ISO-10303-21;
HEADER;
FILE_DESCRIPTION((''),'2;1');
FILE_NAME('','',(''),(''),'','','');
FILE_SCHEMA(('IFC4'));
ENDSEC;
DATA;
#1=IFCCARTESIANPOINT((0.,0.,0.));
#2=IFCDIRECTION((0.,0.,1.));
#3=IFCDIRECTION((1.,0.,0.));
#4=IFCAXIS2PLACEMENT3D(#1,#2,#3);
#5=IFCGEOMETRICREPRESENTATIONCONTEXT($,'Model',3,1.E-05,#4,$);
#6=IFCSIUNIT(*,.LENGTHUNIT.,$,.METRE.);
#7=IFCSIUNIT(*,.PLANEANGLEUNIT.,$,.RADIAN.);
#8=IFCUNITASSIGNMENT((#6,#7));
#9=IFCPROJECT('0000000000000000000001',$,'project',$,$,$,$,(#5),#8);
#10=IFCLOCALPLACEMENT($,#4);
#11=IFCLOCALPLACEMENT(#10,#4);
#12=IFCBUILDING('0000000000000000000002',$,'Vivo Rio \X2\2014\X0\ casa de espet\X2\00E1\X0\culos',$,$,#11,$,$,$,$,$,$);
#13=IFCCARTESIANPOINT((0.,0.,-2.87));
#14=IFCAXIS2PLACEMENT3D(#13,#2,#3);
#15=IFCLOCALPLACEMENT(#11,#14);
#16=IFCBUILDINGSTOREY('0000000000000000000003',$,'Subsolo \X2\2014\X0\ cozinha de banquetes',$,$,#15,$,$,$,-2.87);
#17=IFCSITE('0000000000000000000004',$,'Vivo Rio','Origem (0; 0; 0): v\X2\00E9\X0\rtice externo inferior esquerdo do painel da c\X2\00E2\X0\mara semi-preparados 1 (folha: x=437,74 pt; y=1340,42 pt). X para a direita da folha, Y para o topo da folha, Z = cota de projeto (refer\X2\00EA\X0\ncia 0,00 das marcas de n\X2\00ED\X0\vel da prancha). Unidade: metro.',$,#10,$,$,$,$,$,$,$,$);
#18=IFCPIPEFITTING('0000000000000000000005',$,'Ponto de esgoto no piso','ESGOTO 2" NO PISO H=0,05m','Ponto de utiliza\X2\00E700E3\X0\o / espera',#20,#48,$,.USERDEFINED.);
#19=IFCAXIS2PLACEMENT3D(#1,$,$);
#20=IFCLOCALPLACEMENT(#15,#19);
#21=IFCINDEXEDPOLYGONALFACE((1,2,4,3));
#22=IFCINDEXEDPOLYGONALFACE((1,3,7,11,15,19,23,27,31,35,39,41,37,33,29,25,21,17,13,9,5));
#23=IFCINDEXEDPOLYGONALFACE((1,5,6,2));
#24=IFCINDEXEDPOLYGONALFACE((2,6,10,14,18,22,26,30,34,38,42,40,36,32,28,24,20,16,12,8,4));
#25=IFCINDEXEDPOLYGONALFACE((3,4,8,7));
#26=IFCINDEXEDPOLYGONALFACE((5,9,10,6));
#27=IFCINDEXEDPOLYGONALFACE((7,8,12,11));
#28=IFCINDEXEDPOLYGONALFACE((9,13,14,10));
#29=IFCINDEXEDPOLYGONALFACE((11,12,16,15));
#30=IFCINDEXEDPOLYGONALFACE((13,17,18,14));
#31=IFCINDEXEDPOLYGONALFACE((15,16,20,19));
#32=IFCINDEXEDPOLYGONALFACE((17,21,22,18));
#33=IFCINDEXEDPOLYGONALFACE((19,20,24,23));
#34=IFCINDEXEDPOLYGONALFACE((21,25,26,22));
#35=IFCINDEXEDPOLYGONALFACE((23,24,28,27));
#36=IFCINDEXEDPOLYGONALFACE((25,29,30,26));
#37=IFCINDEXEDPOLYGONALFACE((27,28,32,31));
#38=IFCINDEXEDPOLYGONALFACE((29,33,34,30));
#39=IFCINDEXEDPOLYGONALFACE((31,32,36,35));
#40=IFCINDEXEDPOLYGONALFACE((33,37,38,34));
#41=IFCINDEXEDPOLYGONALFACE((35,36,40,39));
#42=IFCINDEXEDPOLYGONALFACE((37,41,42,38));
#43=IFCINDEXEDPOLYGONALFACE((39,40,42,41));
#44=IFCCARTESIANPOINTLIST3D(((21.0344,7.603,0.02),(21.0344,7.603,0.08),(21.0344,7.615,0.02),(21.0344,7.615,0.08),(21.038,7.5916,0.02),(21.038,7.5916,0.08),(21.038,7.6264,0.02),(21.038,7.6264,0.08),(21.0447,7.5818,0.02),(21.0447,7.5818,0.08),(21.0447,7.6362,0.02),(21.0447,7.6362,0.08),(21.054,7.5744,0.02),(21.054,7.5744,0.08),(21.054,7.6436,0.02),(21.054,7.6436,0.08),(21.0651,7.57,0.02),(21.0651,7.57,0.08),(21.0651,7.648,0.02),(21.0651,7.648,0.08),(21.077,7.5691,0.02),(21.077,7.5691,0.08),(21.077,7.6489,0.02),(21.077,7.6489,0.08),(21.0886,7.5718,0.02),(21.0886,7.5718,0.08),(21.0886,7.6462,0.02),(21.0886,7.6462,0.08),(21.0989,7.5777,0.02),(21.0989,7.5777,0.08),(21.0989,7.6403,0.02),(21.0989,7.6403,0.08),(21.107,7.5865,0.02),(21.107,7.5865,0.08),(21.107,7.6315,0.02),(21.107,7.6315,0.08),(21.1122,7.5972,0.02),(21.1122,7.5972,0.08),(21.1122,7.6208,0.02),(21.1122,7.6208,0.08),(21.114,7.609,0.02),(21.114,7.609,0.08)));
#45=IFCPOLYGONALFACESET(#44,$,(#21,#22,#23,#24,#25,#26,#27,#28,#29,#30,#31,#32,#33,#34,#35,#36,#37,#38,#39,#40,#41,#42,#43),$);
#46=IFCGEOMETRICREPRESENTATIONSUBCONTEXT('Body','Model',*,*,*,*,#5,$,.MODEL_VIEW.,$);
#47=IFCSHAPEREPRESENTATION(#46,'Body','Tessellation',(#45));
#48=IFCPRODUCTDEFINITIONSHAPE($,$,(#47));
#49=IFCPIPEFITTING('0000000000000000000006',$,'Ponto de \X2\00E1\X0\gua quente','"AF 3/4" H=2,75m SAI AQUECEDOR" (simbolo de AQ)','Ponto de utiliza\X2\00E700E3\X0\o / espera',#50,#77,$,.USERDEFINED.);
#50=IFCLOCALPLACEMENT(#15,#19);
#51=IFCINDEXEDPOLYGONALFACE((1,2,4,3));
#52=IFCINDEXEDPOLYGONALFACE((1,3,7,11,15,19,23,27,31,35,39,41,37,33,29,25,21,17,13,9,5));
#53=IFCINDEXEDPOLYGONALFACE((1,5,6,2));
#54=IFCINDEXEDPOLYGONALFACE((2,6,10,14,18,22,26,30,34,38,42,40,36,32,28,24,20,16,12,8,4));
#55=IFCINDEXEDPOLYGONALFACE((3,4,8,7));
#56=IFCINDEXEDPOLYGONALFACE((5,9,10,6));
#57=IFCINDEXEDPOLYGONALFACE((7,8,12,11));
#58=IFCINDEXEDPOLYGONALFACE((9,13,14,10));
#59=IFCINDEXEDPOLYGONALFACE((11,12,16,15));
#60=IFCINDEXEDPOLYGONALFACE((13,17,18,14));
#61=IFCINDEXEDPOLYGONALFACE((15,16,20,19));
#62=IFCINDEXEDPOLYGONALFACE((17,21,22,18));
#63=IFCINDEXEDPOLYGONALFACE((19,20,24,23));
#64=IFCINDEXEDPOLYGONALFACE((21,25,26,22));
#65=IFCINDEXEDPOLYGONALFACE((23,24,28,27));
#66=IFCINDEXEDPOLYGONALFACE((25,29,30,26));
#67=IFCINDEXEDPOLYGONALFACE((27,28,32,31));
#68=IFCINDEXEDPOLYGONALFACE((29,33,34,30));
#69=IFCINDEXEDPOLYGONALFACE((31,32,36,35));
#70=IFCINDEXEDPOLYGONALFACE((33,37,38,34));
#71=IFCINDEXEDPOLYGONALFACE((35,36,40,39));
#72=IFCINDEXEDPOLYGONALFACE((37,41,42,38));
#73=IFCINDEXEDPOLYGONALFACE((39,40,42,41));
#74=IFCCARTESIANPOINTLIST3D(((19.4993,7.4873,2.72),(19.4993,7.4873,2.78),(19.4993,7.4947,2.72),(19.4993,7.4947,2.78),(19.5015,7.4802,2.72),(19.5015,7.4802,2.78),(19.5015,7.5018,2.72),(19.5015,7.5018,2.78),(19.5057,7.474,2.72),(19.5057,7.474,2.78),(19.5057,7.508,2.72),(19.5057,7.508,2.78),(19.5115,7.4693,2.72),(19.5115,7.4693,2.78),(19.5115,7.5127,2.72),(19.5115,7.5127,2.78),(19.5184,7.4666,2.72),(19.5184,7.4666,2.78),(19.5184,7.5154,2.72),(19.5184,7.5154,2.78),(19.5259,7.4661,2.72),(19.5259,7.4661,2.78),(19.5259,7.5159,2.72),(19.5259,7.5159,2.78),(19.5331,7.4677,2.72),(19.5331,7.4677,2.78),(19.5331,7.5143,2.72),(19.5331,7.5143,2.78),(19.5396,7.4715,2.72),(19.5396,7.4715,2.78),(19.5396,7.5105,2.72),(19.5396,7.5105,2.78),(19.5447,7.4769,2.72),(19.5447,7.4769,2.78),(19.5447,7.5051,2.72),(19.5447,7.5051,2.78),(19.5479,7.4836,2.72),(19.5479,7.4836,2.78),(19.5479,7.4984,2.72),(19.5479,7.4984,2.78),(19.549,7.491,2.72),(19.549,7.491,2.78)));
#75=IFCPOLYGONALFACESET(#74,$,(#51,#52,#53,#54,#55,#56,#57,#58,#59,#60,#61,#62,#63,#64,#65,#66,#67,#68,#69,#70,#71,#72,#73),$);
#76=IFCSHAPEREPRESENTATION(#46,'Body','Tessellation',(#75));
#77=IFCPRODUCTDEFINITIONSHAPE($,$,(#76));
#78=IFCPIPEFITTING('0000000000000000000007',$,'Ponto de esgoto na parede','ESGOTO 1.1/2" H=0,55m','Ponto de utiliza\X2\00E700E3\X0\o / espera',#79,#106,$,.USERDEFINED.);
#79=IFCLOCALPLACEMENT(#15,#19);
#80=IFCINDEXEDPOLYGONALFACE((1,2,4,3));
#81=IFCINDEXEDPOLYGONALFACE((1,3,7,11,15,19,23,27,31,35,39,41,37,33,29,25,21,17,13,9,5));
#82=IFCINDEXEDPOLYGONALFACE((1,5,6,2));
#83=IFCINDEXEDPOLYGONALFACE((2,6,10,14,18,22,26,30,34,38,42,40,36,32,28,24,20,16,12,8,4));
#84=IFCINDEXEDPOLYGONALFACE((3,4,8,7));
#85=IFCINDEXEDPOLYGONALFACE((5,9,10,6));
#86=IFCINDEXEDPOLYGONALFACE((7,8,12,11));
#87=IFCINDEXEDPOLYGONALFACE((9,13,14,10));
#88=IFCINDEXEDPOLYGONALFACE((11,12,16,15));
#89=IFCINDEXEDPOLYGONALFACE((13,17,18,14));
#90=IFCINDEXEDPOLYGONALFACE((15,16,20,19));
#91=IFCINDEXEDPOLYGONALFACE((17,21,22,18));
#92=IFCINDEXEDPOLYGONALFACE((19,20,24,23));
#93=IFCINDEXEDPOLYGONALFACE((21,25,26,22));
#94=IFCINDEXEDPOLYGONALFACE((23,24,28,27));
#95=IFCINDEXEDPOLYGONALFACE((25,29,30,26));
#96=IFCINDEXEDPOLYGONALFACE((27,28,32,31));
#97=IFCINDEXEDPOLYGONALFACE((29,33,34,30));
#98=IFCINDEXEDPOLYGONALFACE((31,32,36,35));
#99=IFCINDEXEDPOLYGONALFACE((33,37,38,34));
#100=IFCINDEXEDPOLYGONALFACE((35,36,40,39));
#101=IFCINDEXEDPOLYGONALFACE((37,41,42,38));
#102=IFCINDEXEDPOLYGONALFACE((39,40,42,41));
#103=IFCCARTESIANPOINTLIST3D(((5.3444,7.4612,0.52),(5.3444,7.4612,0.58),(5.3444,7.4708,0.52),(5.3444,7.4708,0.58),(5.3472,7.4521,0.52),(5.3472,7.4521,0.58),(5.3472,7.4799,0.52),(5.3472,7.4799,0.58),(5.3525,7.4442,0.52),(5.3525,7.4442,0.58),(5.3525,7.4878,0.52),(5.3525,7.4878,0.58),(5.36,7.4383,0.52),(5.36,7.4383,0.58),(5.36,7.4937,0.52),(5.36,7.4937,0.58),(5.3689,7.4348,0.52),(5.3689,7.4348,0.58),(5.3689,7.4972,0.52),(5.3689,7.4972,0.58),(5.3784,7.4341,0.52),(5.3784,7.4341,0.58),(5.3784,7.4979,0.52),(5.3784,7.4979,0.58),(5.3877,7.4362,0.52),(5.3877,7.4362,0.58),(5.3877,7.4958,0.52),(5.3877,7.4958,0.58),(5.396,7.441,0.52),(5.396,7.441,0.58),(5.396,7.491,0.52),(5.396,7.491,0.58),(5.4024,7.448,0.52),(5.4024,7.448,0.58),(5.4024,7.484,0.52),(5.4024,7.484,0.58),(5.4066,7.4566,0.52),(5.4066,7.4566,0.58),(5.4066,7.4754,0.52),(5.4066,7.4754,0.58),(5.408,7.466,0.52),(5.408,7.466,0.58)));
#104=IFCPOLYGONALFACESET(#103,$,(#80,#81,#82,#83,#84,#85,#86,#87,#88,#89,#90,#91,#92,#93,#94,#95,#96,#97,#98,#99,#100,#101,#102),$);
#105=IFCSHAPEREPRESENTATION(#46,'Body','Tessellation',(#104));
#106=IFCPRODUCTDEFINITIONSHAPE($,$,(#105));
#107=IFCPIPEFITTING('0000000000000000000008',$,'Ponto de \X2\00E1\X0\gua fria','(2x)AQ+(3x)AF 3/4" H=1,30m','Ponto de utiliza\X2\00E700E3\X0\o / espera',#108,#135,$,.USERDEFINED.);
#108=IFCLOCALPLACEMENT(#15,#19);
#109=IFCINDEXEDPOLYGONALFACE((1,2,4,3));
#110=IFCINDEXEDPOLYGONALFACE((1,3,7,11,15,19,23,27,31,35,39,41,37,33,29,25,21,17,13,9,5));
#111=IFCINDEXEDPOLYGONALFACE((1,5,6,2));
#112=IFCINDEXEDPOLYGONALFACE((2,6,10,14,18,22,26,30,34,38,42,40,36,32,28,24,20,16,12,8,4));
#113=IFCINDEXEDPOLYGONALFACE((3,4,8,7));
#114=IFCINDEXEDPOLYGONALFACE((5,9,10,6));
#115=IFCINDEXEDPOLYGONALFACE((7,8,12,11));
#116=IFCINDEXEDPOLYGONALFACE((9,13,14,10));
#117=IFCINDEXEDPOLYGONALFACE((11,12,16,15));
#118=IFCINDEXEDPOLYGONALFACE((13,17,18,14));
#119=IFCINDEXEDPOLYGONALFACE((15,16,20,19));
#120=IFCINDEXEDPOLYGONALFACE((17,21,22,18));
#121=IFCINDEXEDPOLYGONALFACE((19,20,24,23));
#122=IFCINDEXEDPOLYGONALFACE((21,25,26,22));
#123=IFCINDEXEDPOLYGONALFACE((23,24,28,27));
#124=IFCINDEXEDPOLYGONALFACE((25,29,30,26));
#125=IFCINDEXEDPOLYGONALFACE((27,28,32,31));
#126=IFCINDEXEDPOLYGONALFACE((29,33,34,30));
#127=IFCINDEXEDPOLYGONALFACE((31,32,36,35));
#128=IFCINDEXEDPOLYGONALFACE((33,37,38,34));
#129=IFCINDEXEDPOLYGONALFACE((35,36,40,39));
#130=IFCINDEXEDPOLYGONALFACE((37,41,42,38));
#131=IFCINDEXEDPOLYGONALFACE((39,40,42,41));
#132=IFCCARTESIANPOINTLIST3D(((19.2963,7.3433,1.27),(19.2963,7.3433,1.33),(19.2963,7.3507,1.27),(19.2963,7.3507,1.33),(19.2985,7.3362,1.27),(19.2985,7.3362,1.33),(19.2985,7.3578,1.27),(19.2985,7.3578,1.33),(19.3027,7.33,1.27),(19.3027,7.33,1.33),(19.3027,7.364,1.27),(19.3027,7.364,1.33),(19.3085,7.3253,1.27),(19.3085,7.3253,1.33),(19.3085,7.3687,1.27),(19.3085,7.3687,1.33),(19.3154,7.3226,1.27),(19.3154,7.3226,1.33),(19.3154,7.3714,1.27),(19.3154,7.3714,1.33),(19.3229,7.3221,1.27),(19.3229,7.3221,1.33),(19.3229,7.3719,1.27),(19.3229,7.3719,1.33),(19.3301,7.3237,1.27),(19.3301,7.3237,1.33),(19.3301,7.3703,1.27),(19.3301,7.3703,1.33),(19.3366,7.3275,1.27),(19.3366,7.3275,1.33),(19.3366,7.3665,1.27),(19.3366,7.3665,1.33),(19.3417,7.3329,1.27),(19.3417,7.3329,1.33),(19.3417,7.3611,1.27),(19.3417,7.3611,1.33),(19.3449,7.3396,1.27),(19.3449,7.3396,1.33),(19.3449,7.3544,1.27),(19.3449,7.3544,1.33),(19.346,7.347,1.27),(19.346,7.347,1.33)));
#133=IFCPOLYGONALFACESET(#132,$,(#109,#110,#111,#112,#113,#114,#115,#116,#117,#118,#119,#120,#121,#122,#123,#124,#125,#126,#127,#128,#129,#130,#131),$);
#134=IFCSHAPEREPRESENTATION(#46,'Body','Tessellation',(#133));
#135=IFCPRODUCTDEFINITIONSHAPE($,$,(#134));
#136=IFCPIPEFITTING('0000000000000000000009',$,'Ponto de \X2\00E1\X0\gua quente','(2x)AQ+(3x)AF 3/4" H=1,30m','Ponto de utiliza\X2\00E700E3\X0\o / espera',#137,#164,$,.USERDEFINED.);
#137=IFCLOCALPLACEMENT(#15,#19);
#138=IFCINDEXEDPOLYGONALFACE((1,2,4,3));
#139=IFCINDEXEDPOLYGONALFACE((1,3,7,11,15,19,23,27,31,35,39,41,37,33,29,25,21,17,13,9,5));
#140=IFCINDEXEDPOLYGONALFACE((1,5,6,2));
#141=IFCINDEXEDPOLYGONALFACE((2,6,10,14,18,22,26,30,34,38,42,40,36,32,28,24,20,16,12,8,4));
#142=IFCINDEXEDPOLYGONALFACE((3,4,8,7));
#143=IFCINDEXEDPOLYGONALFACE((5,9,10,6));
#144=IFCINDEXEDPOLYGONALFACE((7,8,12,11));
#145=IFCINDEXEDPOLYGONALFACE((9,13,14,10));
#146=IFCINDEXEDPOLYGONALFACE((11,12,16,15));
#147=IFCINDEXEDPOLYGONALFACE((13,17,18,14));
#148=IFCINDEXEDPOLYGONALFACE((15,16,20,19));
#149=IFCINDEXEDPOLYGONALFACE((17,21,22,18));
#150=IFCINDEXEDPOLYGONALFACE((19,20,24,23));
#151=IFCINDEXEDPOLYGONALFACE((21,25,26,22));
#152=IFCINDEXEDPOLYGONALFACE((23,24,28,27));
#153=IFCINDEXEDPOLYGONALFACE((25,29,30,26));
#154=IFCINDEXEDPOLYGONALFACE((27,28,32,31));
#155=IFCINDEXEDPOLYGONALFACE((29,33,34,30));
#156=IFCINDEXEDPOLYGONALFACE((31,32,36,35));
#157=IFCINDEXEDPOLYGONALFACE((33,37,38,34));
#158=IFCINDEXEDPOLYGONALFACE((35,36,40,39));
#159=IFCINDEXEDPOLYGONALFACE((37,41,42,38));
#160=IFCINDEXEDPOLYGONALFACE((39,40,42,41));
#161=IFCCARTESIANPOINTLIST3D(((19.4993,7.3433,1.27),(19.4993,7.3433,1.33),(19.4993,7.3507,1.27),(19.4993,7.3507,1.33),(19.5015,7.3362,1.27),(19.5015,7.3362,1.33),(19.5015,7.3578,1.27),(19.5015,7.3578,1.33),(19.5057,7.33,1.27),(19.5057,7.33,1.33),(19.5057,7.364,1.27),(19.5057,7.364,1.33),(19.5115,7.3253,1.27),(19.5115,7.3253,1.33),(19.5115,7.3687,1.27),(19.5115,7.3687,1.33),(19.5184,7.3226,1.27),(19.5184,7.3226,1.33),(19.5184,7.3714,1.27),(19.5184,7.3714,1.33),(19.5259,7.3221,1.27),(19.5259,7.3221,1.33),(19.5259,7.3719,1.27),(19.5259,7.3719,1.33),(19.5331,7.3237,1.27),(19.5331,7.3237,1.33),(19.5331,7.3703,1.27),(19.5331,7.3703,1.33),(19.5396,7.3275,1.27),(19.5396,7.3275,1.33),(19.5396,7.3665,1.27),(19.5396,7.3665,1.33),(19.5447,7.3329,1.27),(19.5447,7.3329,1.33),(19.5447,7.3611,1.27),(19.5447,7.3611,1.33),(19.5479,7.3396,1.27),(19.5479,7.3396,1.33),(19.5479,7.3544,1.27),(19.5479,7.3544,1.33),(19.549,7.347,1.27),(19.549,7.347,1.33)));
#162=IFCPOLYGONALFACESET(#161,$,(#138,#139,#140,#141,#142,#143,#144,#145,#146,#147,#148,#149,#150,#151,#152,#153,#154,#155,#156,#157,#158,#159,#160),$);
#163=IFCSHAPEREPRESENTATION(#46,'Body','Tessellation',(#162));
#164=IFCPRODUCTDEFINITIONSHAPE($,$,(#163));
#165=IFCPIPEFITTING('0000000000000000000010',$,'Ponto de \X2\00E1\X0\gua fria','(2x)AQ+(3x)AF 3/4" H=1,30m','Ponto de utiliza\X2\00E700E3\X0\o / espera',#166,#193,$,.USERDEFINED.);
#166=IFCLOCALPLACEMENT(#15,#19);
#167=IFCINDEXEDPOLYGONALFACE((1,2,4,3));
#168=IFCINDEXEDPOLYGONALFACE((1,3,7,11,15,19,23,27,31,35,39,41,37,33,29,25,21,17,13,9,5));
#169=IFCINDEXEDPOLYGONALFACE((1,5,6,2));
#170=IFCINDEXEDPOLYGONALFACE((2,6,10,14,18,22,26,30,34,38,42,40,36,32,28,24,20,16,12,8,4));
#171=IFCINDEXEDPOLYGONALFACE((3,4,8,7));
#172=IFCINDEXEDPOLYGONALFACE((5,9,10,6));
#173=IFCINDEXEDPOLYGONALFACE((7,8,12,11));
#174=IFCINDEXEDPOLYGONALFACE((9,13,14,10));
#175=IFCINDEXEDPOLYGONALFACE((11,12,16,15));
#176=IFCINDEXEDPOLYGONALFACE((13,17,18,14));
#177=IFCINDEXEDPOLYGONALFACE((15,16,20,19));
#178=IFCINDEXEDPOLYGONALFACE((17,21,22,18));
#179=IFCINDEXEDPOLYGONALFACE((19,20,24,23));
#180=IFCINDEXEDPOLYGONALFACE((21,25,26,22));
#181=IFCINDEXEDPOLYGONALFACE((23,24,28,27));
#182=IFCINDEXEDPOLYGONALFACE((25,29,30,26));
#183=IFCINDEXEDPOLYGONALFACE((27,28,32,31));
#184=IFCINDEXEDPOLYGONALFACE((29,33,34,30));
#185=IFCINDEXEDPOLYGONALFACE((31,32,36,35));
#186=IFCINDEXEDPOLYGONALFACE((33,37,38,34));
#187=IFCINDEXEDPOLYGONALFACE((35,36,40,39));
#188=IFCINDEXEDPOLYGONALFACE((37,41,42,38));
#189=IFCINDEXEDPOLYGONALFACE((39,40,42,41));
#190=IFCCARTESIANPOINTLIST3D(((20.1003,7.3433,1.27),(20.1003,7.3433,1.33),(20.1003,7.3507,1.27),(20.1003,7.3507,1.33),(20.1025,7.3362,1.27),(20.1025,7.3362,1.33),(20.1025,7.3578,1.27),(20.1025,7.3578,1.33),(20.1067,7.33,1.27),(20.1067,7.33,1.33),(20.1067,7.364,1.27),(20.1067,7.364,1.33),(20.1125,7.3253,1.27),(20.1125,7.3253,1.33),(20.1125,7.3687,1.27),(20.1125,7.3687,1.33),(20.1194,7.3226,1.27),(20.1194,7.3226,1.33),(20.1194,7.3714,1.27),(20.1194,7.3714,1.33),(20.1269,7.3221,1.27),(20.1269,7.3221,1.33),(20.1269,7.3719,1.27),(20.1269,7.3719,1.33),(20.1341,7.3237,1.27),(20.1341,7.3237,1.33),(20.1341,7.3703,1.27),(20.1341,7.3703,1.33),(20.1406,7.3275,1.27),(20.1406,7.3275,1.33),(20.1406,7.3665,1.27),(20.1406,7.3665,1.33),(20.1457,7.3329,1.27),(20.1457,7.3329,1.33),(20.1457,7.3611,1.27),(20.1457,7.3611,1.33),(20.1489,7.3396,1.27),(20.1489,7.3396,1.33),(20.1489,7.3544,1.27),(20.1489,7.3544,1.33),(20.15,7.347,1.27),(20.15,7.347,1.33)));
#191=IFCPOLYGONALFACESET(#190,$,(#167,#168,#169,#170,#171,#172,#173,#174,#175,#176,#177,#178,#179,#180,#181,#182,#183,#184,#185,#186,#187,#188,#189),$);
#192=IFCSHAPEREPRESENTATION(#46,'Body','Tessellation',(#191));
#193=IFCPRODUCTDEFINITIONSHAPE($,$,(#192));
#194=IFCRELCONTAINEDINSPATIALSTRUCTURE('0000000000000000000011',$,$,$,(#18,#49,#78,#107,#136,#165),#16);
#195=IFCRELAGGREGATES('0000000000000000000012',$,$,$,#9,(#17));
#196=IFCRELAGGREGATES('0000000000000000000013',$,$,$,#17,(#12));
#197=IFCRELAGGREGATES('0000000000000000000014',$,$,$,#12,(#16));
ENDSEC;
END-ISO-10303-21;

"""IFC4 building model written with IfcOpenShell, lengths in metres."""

from ifc_helpers import new_model, si_unit, frame, origin_with_axes, origin_2d, place, context, subcontext, project, spatial, circle, extrude, element, save


model = new_model("IFC4")

# Units and contexts
model_context = context("Model", 3, precision=1e-05, world=origin_with_axes())
body_context = subcontext(model_context, "Body", "Model", "MODEL_VIEW")
ifc_project = project(units=[si_unit("LENGTHUNIT", "METRE"), si_unit("PLANEANGLEUNIT", "RADIAN")], contexts=[model_context])

# Site, building, storey
site_placement = place(None, origin_with_axes())
site = spatial("IfcSite", under=ifc_project, at=site_placement, Name="Vivo Rio", Description="Origem (0; 0; 0): vértice externo inferior esquerdo do painel da câmara semi-preparados 1 (folha: x=437,74 pt; y=1340,42 pt). X para a direita da folha, Y para o topo da folha, Z = cota de projeto (referência 0,00 das marcas de nível da prancha). Unidade: metro.")
building_placement = place(site_placement, origin_with_axes())
building = spatial("IfcBuilding", under=site, at=building_placement, Name="Vivo Rio — casa de espetáculos")
storey_placement = place(building_placement, frame((0.0, 0.0, -2.87), z_axis=(0.0, 0.0, 1.0), x_axis=(1.0, 0.0, 0.0)))
storey = spatial("IfcBuildingStorey", under=building, at=storey_placement, Name="Subsolo — cozinha de banquetes", Elevation=-2.87)

# Pipe fittings
pipe_fitting_1_placement = place(storey_placement, origin_with_axes())
element("IfcPipeFitting", 1, at=pipe_fitting_1_placement, inside=storey, Name="Ponto de esgoto no piso", Description="ESGOTO 2\" NO PISO H=0,05m", ObjectType="Ponto de utilização / espera", PredefinedType="USERDEFINED", context=body_context, shape_type="SweptSolid", body=[
    extrude(circle(Radius=0.04, at=origin_2d()), frame((21.074, 7.609, 0.02), z_axis=(0.0, 0.0, 1.0), x_axis=(1.0, 0.0, 0.0)), (0.0, 0.0, 1.0), 0.06),
])
pipe_fitting_2_placement = place(storey_placement, origin_with_axes())
element("IfcPipeFitting", 2, at=pipe_fitting_2_placement, inside=storey, Name="Ponto de água quente", Description="\"AF 3/4\" H=2,75m SAI AQUECEDOR\" (simbolo de AQ)", ObjectType="Ponto de utilização / espera", PredefinedType="USERDEFINED", context=body_context, shape_type="SweptSolid", body=[
    extrude(circle(Radius=0.025, at=origin_2d()), frame((19.524, 7.491, 2.72), z_axis=(0.0, 0.0, 1.0), x_axis=(1.0, 0.0, 0.0)), (0.0, 0.0, 1.0), 0.06),
])
pipe_fitting_3_placement = place(storey_placement, origin_with_axes())
element("IfcPipeFitting", 3, at=pipe_fitting_3_placement, inside=storey, Name="Ponto de esgoto na parede", Description="ESGOTO 1.1/2\" H=0,55m", ObjectType="Ponto de utilização / espera", PredefinedType="USERDEFINED", context=body_context, shape_type="SweptSolid", body=[
    extrude(circle(Radius=0.032, at=origin_2d()), frame((5.376, 7.466, 0.52), z_axis=(0.0, 0.0, 1.0), x_axis=(1.0, 0.0, 0.0)), (0.0, 0.0, 1.0), 0.06),
])
pipe_fitting_4_placement = place(storey_placement, origin_with_axes())
element("IfcPipeFitting", 4, at=pipe_fitting_4_placement, inside=storey, Name="Ponto de água fria", Description="(2x)AQ+(3x)AF 3/4\" H=1,30m", ObjectType="Ponto de utilização / espera", PredefinedType="USERDEFINED", context=body_context, shape_type="SweptSolid", body=[
    extrude(circle(Radius=0.025, at=origin_2d()), frame((19.321, 7.347, 1.27), z_axis=(0.0, 0.0, 1.0), x_axis=(1.0, 0.0, 0.0)), (0.0, 0.0, 1.0), 0.06),
])
pipe_fitting_5_placement = place(storey_placement, origin_with_axes())
element("IfcPipeFitting", 5, at=pipe_fitting_5_placement, inside=storey, Name="Ponto de água quente", Description="(2x)AQ+(3x)AF 3/4\" H=1,30m", ObjectType="Ponto de utilização / espera", PredefinedType="USERDEFINED", context=body_context, shape_type="SweptSolid", body=[
    extrude(circle(Radius=0.025, at=origin_2d()), frame((19.524, 7.347, 1.27), z_axis=(0.0, 0.0, 1.0), x_axis=(1.0, 0.0, 0.0)), (0.0, 0.0, 1.0), 0.06),
])
pipe_fitting_6_placement = place(storey_placement, origin_with_axes())
element("IfcPipeFitting", 6, at=pipe_fitting_6_placement, inside=storey, Name="Ponto de água fria", Description="(2x)AQ+(3x)AF 3/4\" H=1,30m", ObjectType="Ponto de utilização / espera", PredefinedType="USERDEFINED", context=body_context, shape_type="SweptSolid", body=[
    extrude(circle(Radius=0.025, at=origin_2d()), frame((20.125, 7.347, 1.27), z_axis=(0.0, 0.0, 1.0), x_axis=(1.0, 0.0, 0.0)), (0.0, 0.0, 1.0), 0.06),
])

save(model, "model.ifc")
